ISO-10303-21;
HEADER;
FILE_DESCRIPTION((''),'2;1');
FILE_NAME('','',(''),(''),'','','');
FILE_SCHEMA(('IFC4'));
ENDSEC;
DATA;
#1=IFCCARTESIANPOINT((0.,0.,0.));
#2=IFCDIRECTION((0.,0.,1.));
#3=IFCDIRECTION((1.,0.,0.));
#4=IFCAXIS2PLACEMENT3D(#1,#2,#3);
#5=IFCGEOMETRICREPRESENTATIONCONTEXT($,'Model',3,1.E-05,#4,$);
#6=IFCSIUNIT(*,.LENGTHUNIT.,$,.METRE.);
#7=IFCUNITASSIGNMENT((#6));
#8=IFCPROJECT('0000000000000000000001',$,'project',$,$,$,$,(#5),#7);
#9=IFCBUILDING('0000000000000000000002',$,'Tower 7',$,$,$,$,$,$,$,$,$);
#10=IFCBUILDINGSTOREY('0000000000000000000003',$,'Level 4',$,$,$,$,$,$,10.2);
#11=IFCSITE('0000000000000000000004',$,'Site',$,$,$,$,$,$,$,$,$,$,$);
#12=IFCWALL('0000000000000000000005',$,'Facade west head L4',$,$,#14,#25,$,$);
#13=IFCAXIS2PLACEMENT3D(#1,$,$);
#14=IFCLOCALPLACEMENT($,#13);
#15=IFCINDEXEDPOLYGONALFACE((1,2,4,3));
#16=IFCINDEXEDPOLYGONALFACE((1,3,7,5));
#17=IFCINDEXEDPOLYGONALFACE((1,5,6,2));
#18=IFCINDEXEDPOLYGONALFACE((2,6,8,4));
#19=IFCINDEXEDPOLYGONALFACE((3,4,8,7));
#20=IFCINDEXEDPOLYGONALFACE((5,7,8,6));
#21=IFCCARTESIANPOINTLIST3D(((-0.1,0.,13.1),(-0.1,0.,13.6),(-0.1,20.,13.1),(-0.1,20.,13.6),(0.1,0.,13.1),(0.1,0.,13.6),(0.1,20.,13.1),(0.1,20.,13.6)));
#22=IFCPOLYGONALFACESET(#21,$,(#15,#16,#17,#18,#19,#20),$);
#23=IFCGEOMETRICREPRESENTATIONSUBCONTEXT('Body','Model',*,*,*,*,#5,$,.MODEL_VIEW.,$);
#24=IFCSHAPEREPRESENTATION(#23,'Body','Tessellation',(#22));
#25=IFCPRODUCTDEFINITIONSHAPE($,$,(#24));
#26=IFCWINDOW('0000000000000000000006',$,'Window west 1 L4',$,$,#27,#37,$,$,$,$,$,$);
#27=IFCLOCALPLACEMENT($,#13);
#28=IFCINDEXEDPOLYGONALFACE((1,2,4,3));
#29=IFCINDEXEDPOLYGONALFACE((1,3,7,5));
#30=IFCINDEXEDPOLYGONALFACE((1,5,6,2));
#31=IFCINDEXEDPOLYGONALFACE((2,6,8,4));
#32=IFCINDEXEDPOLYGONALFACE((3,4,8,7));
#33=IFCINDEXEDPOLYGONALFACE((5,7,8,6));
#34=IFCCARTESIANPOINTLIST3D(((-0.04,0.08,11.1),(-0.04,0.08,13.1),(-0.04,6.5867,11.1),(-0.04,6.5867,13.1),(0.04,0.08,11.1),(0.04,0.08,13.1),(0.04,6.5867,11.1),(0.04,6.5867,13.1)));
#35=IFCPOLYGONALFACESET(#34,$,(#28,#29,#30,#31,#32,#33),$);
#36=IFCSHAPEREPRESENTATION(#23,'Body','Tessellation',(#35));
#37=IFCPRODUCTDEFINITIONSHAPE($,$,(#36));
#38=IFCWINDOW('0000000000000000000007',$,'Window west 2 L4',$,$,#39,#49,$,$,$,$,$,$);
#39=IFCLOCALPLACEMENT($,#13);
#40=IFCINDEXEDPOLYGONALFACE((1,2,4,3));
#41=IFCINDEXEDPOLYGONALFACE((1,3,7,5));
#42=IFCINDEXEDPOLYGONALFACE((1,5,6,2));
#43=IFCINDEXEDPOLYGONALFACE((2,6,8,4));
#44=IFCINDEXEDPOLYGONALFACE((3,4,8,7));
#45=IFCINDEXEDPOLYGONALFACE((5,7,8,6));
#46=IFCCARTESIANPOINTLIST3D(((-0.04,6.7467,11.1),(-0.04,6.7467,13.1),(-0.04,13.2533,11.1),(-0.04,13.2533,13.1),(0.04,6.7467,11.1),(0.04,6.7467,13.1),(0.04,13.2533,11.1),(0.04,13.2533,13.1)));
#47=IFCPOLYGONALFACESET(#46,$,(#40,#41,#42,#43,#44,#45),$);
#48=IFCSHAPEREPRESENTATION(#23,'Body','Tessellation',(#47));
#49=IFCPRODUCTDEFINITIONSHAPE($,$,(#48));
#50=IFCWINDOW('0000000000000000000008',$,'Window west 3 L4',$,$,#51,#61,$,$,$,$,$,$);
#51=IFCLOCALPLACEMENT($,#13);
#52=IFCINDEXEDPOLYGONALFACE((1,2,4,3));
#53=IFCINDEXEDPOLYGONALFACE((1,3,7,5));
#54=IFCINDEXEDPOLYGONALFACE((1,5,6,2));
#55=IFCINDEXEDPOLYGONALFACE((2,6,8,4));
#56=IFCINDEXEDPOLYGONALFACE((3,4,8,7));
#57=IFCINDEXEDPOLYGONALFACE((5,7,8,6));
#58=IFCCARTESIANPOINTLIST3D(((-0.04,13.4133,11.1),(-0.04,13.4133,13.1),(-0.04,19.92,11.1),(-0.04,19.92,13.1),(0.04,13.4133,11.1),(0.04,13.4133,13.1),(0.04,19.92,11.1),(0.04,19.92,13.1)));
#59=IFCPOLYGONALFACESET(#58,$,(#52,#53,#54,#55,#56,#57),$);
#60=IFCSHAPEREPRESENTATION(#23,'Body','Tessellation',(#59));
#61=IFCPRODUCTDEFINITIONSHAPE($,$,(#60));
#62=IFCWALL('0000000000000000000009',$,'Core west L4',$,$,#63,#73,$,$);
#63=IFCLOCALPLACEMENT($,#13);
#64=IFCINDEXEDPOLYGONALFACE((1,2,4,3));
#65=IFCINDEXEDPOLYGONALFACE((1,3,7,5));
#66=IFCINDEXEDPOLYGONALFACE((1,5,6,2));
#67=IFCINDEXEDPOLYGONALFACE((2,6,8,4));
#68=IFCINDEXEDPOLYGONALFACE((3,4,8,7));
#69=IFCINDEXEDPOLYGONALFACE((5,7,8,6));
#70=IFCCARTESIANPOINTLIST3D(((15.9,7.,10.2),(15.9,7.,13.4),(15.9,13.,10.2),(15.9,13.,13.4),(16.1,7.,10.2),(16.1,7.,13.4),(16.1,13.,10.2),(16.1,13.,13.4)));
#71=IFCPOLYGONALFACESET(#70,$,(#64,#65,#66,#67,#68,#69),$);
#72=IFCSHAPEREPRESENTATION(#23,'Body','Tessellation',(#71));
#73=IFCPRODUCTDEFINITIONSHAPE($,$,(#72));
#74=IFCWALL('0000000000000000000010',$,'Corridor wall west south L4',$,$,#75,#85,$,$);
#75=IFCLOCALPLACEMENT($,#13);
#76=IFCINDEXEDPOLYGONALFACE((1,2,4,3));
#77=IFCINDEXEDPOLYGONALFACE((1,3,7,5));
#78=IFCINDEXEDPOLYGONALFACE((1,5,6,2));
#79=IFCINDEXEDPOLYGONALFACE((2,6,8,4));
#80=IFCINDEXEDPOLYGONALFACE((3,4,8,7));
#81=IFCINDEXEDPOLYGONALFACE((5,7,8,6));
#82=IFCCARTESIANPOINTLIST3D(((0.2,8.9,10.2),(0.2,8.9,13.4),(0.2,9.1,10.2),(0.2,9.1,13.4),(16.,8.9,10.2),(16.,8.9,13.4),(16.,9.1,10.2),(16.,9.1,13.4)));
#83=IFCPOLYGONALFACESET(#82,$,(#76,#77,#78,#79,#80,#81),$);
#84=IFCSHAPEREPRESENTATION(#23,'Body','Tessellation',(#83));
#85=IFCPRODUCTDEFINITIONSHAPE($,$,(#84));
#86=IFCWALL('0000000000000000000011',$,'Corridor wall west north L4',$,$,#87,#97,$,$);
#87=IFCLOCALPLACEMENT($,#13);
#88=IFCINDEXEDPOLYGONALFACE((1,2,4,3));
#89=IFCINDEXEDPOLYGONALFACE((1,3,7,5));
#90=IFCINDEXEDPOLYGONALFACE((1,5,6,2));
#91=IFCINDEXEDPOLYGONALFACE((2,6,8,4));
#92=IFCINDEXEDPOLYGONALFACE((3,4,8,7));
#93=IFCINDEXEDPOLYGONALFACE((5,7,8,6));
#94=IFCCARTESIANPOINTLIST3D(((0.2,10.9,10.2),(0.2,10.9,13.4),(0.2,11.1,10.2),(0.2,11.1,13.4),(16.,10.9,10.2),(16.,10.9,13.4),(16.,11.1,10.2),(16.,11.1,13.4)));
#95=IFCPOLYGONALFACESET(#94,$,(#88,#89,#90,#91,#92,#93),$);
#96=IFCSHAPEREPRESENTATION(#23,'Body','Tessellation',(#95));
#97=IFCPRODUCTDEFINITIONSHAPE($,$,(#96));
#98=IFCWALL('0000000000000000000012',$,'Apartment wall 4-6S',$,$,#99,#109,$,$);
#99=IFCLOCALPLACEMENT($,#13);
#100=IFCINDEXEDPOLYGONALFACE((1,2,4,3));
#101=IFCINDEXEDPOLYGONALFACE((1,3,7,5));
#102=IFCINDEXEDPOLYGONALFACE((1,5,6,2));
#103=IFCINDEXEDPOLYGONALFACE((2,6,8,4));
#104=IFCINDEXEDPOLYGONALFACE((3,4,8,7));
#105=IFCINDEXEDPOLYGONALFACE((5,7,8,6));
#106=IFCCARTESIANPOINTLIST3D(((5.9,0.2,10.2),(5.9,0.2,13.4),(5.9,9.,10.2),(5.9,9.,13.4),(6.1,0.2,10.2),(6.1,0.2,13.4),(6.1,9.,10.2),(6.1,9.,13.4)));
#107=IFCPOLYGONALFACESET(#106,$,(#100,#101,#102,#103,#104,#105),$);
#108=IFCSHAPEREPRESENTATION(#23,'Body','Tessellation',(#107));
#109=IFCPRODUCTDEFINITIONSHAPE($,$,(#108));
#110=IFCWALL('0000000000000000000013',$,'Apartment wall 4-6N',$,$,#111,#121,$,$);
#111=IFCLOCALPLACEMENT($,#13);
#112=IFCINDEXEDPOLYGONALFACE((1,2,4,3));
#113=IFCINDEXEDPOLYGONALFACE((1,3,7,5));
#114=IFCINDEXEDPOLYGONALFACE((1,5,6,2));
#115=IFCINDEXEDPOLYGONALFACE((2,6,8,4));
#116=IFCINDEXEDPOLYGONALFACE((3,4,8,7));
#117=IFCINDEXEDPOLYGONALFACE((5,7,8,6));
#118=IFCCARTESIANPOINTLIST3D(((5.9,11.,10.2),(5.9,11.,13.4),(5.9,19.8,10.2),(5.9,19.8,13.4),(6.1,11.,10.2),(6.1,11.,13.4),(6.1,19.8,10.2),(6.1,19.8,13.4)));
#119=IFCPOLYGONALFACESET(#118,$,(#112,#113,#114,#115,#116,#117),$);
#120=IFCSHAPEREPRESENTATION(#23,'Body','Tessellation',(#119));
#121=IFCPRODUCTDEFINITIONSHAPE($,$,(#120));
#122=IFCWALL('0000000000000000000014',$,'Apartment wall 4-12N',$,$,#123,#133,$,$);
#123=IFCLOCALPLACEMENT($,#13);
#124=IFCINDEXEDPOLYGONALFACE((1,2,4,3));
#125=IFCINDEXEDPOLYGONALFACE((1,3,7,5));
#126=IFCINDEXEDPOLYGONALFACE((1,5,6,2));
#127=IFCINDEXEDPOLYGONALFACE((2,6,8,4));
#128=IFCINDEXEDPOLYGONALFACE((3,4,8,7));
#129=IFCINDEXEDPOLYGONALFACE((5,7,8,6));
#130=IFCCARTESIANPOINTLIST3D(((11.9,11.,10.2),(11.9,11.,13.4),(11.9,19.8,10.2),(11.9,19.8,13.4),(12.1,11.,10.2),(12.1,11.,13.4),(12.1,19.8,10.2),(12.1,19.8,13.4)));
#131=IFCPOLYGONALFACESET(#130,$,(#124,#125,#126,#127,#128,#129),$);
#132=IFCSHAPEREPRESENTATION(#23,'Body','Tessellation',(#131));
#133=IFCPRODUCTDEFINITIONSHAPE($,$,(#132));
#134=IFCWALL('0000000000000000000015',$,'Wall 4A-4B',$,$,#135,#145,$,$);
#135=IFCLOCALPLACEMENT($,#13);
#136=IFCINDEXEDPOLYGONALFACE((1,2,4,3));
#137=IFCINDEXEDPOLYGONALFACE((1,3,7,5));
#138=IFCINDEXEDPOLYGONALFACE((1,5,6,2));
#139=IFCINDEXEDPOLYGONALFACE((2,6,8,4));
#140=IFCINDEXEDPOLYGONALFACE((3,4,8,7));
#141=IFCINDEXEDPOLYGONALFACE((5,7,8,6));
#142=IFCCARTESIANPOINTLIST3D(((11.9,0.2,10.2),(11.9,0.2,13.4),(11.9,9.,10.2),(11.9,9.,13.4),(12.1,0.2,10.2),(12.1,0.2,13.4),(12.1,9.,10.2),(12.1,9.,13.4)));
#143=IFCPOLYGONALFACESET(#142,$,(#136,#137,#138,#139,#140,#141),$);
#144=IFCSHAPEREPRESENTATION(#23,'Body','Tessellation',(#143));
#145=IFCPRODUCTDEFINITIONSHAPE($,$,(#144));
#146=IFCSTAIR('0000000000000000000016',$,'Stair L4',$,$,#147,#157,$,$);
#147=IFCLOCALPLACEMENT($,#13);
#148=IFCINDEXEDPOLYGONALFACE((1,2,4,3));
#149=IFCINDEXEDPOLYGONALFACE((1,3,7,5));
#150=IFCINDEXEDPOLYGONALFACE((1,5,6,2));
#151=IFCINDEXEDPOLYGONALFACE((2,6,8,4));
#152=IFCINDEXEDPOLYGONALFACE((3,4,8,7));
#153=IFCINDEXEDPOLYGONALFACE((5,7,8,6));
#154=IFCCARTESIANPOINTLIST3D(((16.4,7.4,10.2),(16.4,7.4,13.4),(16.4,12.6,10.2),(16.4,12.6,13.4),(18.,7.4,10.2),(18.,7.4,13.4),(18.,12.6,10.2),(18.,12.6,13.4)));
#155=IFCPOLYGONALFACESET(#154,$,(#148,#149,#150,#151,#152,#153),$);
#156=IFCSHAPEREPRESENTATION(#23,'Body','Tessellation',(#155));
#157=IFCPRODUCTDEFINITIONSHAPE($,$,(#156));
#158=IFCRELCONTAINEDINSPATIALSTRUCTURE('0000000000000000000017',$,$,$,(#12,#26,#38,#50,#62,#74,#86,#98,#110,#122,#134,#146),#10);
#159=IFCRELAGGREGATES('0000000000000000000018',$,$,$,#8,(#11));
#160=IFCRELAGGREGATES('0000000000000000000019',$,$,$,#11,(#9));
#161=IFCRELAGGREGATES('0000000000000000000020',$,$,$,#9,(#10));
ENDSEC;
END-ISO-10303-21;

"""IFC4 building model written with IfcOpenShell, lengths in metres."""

from ifc_helpers import new_model, si_unit, frame, origin, origin_with_axes, origin_2d, place, context, subcontext, project, spatial, rectangle, extrude, element, save


model = new_model("IFC4")

# Units and contexts
model_context = context("Model", 3, precision=1e-05, world=origin_with_axes())
body_context = subcontext(model_context, "Body", "Model", "MODEL_VIEW")
ifc_project = project(units=[si_unit("LENGTHUNIT", "METRE")], contexts=[model_context])

# Site, building, storey
site = spatial("IfcSite", under=ifc_project, Name="Site")
building = spatial("IfcBuilding", under=site, Name="Tower 7")
storey = spatial("IfcBuildingStorey", under=building, Name="Level 4", Elevation=10.2)

# Wall
wall_1_placement = place(None, frame((0.0, 10.0, 13.1), z_axis=(0.0, 0.0, 1.0), x_axis=(1.0, 0.0, 0.0)))
element("IfcWall", 1, at=wall_1_placement, inside=storey, Name="Facade west head L4", context=body_context, shape_type="SweptSolid", body=[
    extrude(rectangle(XDim=0.2, YDim=20.0, at=origin_2d()), origin(), (0.0, 0.0, 1.0), 0.5),
])

# Windows
for number, where, z_axis, x_axis, name in (
    (2, (0.0, 3.3333, 11.1), (0.0, 0.0, 1.0), (1.0, 0.0, 0.0), "Window west 1 L4"),
    (3, (0.0, 10.0, 11.1), (0.0, 0.0, 1.0), (1.0, 0.0, 0.0), "Window west 2 L4"),
):
    element("IfcWindow", number, at=place(None, frame(where, z_axis=z_axis, x_axis=x_axis)), inside=storey, Name=name, context=body_context, shape_type="SweptSolid", body=[
        extrude(rectangle(XDim=0.08, YDim=6.5067, at=origin_2d()), origin(), (0.0, 0.0, 1.0), 2.0),
    ])
window_1_placement = place(None, frame((0.0, 16.6667, 11.1), z_axis=(0.0, 0.0, 1.0), x_axis=(1.0, 0.0, 0.0)))
element("IfcWindow", 4, at=window_1_placement, inside=storey, Name="Window west 3 L4", context=body_context, shape_type="SweptSolid", body=[
    extrude(rectangle(XDim=0.08, YDim=6.5067, at=origin_2d()), origin(), (0.0, 0.0, 1.0), 2.0),
])

# Walls
wall_2_placement = place(None, frame((16.0, 10.0, 10.2), z_axis=(0.0, 0.0, 1.0), x_axis=(1.0, 0.0, 0.0)))
element("IfcWall", 5, at=wall_2_placement, inside=storey, Name="Core west L4", context=body_context, shape_type="SweptSolid", body=[
    extrude(rectangle(XDim=0.2, YDim=6.0, at=origin_2d()), origin(), (0.0, 0.0, 1.0), 3.2),
])
for number, where, z_axis, x_axis, name in (
    (6, (8.1, 9.0, 10.2), (0.0, 0.0, 1.0), (1.0, 0.0, 0.0), "Corridor wall west south L4"),
    (7, (8.1, 11.0, 10.2), (0.0, 0.0, 1.0), (1.0, 0.0, 0.0), "Corridor wall west north L4"),
):
    element("IfcWall", number, at=place(None, frame(where, z_axis=z_axis, x_axis=x_axis)), inside=storey, Name=name, context=body_context, shape_type="SweptSolid", body=[
        extrude(rectangle(XDim=15.8, YDim=0.2, at=origin_2d()), origin(), (0.0, 0.0, 1.0), 3.2),
    ])
for number, where, z_axis, x_axis, name in (
    (8, (6.0, 4.6, 10.2), (0.0, 0.0, 1.0), (1.0, 0.0, 0.0), "Apartment wall 4-6S"),
    (9, (6.0, 15.4, 10.2), (0.0, 0.0, 1.0), (1.0, 0.0, 0.0), "Apartment wall 4-6N"),
    (10, (12.0, 15.4, 10.2), (0.0, 0.0, 1.0), (1.0, 0.0, 0.0), "Apartment wall 4-12N"),
    (11, (12.0, 4.6, 10.2), (0.0, 0.0, 1.0), (1.0, 0.0, 0.0), "Wall 4A-4B"),
):
    element("IfcWall", number, at=place(None, frame(where, z_axis=z_axis, x_axis=x_axis)), inside=storey, Name=name, context=body_context, shape_type="SweptSolid", body=[
        extrude(rectangle(XDim=0.2, YDim=8.8, at=origin_2d()), origin(), (0.0, 0.0, 1.0), 3.2),
    ])

# Stair
stair_placement = place(None, frame((17.2, 10.0, 10.2), z_axis=(0.0, 0.0, 1.0), x_axis=(1.0, 0.0, 0.0)))
element("IfcStair", 12, at=stair_placement, inside=storey, Name="Stair L4", context=body_context, shape_type="SweptSolid", body=[
    extrude(rectangle(XDim=1.6, YDim=5.2, at=origin_2d()), origin(), (0.0, 0.0, 1.0), 3.2),
])

save(model, "model.ifc")
